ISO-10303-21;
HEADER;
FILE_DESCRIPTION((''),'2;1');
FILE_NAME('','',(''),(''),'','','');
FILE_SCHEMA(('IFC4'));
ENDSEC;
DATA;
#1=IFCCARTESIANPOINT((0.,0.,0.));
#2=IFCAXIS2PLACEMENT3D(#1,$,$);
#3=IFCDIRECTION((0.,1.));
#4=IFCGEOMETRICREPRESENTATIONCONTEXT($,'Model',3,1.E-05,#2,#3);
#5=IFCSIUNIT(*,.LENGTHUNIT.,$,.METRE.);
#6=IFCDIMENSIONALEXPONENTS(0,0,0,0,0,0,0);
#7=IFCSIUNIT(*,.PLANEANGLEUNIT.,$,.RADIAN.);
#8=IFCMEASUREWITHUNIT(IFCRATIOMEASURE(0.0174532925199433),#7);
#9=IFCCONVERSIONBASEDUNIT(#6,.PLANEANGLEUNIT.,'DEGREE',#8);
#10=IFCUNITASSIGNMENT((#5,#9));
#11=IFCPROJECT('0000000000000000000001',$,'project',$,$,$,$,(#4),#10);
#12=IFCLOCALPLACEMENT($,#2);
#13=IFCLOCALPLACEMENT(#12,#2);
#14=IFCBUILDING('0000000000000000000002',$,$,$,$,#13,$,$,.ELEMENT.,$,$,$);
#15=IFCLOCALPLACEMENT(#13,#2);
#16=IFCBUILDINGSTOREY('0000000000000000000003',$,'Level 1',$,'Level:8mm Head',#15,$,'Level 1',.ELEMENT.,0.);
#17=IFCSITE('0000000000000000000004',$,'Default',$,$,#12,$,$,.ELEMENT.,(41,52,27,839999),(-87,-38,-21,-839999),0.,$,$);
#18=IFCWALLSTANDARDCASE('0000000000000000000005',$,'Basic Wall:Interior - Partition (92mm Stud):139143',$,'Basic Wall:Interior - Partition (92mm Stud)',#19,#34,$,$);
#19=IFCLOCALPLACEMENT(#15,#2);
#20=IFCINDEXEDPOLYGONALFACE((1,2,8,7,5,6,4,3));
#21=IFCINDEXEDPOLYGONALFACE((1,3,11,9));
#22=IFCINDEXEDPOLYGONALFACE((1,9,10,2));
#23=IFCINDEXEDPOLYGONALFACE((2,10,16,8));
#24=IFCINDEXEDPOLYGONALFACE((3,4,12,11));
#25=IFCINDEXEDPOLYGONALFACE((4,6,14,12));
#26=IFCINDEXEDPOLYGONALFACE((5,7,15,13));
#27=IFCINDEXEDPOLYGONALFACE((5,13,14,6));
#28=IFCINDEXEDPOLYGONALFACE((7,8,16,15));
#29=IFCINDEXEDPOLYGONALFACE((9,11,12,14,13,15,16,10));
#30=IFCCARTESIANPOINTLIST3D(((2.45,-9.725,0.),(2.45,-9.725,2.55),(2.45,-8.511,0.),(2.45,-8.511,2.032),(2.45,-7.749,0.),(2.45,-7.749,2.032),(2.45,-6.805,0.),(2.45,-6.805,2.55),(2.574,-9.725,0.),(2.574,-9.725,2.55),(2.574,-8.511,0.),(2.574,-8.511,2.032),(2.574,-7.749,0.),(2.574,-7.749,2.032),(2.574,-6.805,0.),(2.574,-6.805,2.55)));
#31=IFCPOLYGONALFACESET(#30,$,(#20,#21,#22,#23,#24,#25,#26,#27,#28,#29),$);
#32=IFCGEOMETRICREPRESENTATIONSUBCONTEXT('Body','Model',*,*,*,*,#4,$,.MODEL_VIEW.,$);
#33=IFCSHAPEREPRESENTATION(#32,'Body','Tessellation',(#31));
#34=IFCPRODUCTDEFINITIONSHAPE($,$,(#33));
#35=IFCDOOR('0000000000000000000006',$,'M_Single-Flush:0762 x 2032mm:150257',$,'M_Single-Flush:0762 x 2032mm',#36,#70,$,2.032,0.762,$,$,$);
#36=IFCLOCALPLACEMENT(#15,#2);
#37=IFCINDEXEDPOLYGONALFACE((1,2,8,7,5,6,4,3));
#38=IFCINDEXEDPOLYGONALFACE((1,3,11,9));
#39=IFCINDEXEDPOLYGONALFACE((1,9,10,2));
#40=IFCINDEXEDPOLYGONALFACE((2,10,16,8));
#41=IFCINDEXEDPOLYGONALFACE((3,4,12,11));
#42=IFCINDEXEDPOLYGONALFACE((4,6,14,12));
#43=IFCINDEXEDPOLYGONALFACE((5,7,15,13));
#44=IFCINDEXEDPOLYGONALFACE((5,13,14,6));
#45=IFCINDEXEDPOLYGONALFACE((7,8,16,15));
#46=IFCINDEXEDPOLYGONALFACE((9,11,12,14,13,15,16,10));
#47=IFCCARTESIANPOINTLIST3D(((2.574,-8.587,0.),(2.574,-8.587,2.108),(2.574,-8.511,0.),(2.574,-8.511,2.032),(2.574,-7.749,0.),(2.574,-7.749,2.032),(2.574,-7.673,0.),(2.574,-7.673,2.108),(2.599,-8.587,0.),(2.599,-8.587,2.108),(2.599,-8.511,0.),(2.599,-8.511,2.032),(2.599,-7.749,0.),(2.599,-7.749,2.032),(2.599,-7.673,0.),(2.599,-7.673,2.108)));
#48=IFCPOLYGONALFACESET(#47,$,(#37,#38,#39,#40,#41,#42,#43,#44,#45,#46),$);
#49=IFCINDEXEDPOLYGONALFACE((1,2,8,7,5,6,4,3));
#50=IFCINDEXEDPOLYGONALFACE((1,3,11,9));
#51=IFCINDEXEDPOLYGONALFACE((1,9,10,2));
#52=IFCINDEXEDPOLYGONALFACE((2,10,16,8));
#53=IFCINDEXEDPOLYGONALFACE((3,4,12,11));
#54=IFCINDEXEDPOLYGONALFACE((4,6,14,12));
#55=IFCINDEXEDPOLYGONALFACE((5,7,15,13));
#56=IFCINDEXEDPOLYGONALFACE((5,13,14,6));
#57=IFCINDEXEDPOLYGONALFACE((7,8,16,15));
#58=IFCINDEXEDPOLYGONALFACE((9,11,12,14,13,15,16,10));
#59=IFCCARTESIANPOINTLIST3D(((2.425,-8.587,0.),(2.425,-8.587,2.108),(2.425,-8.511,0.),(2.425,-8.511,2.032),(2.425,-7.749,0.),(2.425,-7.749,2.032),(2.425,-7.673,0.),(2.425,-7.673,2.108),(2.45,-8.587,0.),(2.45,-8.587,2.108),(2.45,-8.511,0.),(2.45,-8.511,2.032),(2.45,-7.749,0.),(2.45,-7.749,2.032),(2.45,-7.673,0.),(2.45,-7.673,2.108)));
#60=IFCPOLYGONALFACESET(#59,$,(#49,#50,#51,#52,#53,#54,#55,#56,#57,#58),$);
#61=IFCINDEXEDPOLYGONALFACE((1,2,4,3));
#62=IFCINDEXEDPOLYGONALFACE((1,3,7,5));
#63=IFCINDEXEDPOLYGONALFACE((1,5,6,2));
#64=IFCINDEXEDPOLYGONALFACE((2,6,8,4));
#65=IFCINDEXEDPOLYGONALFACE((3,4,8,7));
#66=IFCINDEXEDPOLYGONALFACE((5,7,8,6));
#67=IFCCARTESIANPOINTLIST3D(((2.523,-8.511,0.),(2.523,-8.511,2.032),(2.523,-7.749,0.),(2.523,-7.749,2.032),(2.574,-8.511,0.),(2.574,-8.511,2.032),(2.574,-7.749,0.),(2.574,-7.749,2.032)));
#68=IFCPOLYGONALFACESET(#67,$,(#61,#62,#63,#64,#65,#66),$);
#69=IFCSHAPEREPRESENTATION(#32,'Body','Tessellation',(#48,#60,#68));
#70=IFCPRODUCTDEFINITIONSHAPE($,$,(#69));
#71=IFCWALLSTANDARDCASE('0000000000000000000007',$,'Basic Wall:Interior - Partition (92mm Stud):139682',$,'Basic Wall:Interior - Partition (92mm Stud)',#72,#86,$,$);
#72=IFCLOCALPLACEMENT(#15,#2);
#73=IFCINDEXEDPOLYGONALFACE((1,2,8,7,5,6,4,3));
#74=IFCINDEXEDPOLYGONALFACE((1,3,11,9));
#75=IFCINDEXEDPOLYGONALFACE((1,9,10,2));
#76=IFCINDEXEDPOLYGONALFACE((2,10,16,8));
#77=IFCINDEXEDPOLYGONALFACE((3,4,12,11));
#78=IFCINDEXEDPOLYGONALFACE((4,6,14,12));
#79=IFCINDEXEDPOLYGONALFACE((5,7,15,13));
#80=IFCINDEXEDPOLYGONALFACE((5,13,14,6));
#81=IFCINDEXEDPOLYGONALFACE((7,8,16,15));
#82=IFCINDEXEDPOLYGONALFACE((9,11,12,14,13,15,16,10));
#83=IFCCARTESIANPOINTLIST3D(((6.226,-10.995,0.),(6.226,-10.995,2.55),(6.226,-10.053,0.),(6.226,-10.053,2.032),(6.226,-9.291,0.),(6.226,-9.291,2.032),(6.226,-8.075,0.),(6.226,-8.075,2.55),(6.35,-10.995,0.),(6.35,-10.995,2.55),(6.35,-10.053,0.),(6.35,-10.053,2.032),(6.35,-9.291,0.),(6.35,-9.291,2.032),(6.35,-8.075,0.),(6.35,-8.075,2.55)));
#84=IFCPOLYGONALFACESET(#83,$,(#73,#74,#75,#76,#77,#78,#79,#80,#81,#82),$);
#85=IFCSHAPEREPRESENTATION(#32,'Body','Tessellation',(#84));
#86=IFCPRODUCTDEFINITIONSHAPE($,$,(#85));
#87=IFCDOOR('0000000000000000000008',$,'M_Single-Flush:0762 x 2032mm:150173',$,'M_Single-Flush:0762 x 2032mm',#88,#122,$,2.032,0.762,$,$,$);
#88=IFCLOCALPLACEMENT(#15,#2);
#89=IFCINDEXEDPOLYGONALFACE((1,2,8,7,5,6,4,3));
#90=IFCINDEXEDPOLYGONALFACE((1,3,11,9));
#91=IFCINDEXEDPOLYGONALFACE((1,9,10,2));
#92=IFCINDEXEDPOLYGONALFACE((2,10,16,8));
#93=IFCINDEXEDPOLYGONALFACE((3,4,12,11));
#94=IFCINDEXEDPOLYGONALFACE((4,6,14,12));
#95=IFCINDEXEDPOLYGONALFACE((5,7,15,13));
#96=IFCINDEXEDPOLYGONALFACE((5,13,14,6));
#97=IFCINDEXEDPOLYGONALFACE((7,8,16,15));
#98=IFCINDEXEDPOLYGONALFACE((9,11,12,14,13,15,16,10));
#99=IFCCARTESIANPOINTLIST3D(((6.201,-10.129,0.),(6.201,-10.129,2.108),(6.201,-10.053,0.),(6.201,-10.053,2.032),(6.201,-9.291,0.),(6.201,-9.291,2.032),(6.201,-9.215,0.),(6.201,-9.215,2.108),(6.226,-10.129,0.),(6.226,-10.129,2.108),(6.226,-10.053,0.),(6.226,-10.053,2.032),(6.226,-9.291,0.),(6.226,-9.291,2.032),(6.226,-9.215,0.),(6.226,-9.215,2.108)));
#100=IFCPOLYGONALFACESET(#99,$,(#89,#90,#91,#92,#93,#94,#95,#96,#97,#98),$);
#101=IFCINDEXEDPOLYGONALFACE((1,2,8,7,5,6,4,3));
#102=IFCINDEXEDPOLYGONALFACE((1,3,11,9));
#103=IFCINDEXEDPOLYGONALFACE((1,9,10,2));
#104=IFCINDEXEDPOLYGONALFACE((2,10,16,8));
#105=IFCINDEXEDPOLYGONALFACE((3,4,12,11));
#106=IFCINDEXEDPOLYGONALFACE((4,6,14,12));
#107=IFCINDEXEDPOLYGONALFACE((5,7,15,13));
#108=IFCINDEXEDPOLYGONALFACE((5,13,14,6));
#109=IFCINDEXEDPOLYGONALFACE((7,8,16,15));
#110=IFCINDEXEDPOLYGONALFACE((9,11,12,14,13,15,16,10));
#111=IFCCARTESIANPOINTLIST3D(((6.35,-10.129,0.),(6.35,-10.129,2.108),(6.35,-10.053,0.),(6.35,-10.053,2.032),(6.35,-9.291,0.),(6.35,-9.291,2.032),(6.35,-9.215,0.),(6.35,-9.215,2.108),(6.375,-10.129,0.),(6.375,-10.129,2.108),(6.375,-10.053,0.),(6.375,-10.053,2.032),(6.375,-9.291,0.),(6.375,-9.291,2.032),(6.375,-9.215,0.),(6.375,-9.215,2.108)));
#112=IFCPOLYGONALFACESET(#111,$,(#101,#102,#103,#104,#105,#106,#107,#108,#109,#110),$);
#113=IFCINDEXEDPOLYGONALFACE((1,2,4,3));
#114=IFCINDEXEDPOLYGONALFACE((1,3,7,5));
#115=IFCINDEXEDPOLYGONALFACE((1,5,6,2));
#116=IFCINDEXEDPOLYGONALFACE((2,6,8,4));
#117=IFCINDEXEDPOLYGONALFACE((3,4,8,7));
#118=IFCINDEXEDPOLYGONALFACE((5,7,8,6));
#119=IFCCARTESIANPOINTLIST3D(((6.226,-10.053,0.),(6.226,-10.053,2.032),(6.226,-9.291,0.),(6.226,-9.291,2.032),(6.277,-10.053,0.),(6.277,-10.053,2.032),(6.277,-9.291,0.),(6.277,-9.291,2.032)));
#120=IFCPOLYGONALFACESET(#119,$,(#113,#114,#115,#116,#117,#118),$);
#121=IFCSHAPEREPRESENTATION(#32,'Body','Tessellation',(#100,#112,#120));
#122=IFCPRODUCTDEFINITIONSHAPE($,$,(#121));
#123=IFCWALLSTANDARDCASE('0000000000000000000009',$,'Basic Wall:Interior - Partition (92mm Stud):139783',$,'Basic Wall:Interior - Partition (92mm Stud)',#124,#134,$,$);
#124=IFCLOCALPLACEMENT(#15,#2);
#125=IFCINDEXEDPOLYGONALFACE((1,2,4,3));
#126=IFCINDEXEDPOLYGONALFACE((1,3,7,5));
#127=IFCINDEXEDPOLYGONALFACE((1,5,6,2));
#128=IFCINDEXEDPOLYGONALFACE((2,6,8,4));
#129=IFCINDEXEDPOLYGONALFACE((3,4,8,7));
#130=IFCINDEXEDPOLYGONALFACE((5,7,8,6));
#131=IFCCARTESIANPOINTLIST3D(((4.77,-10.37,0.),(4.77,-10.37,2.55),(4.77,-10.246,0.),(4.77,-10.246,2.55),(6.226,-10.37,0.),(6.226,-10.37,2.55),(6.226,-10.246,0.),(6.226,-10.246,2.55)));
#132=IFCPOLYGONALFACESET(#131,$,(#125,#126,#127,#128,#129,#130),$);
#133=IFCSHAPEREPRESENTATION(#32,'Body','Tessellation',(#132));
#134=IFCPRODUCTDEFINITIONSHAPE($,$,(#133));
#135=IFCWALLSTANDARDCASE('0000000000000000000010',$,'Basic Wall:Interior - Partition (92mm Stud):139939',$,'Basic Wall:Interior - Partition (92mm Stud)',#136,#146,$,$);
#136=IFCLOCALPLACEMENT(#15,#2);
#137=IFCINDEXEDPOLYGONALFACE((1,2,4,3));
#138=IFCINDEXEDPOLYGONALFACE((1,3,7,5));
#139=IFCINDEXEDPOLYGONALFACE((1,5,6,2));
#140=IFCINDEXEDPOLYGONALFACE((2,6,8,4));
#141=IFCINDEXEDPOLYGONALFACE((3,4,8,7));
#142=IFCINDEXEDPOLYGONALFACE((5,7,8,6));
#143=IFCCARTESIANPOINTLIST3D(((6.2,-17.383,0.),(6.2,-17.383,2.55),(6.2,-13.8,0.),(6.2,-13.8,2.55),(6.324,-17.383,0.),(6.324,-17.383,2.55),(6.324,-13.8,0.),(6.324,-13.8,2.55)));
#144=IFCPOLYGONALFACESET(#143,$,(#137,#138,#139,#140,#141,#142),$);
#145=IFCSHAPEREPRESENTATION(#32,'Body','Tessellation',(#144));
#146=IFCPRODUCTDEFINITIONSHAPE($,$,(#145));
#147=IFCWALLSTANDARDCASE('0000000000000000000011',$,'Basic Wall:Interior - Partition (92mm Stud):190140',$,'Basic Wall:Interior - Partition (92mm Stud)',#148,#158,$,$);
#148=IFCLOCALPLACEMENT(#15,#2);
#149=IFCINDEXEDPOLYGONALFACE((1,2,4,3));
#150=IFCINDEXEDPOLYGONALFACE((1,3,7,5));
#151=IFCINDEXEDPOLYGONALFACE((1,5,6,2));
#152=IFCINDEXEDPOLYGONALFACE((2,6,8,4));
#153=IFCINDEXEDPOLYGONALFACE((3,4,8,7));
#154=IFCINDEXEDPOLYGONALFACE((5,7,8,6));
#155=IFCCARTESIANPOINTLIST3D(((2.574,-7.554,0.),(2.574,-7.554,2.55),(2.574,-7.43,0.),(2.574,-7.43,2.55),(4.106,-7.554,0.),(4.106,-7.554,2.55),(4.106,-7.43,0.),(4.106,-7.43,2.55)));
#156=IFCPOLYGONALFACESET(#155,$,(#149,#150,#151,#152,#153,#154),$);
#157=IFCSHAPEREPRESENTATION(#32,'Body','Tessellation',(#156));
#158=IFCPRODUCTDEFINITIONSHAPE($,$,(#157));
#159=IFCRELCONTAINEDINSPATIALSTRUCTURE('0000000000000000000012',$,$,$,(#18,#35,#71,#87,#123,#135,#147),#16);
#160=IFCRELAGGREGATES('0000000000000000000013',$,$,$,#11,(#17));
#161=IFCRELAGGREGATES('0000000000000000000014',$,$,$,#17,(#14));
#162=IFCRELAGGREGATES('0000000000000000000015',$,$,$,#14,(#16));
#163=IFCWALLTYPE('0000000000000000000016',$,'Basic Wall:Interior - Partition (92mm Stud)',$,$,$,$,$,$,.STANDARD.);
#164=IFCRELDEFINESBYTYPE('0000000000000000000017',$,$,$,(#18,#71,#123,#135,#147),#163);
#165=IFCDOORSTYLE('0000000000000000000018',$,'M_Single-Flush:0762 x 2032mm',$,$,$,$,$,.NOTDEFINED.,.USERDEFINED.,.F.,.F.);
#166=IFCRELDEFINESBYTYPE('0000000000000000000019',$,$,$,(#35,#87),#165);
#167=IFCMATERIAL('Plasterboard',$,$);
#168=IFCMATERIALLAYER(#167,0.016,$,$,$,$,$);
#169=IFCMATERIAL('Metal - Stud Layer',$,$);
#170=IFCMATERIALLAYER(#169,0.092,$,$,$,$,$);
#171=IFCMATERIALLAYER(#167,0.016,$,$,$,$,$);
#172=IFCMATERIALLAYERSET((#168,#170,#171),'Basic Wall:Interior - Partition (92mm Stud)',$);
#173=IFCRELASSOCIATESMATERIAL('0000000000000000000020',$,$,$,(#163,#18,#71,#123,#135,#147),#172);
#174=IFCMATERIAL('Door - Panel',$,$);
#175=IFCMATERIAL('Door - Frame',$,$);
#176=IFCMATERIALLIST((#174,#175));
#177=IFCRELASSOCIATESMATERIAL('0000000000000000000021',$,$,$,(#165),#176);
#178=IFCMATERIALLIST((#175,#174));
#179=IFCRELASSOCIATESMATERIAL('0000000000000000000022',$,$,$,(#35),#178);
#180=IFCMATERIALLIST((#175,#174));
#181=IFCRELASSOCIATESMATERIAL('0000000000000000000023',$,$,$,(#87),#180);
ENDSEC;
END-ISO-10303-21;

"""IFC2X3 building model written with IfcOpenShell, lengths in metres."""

from ifc_helpers import new_model, entity, si_unit, converted_unit, direction, frame, frame_2d, origin, place, context, subcontext, project, spatial, polyline, rectangle, outline, extrude, source, transform, mapped, material, material_list, layer, layer_set, layer_usage, type_object, type_shapes, element, fill, save


model = new_model("IFC2X3")

# Units and contexts
model_context = context("Model", 3, precision=1e-05, world=origin(), true_north=direction((0.0, 1.0)))
body_context = subcontext(model_context, "Body", "Model", "MODEL_VIEW")
ifc_project = project(units=[si_unit("LENGTHUNIT", "METRE"), converted_unit("PLANEANGLEUNIT", "DEGREE", entity("IfcRatioMeasure", 0.0174532925199433), si_unit("PLANEANGLEUNIT", "RADIAN"), dimensions=[0, 0, 0, 0, 0, 0, 0])], contexts=[model_context])

# Site, building, storey
site_placement = place(None, origin())
site = spatial("IfcSite", under=ifc_project, at=site_placement, Name="Default", CompositionType="ELEMENT", RefLatitude=(41, 52, 27, 839999), RefLongitude=(-87, -38, -21, -839999), RefElevation=0.0)
building_placement = place(site_placement, origin())
building = spatial("IfcBuilding", under=site, at=building_placement, CompositionType="ELEMENT")
storey_placement = place(building_placement, origin())
storey = spatial("IfcBuildingStorey", under=building, at=storey_placement, Name="Level 1", ObjectType="Level:8mm Head", LongName="Level 1", CompositionType="ELEMENT", Elevation=0.0)

# Shared definitions
ifc_material_1 = material(Name="Metal - Stud Layer")
ifc_material_2 = material(Name="Plasterboard")
ifc_material_3 = material(Name="Door - Frame")
ifc_material_4 = material(Name="Door - Panel")

# Walls, openings, doors
ifc_layer_1 = layer(ifc_material_2, 0.016)
ifc_layer_2 = layer(ifc_material_1, 0.092)
ifc_layer_3 = layer(ifc_material_2, 0.016)
ifc_layer_set_1 = layer_set([ifc_layer_1, ifc_layer_2, ifc_layer_3], Name="Basic Wall:Interior - Partition (92mm Stud)")
ifc_layer_usage_1 = layer_usage(ifc_layer_set_1, "AXIS2", "NEGATIVE", 0.062)
wall_type_1 = type_object("IfcWallType", Name="Basic Wall:Interior - Partition (92mm Stud)", PredefinedType="STANDARD", material=ifc_layer_set_1)
wall_1_placement = place(storey_placement, frame((2.512, -6.805, 0.0), z_axis=(0.0, 0.0, 1.0), x_axis=(0.0, -1.0, 0.0)))
wall_1 = element("IfcWallStandardCase", 1, at=wall_1_placement, inside=storey, type_object=wall_type_1, material=ifc_layer_usage_1, Name="Basic Wall:Interior - Partition (92mm Stud):139143", ObjectType="Basic Wall:Interior - Partition (92mm Stud)", context=body_context, shape_type="SweptSolid", body=[
    extrude(rectangle(XDim=2.92, YDim=0.124, at=frame_2d((1.46, 0.0), x_axis=(-1.0, 0.0))), origin(), (0.0, 0.0, 1.0), 2.55),
])
opening_1_placement = place(wall_1_placement, frame((0.944, -0.062, 0.0)))
opening_1 = element("IfcOpeningElement", 2, at=opening_1_placement, cuts=wall_1, ObjectType="Opening", context=body_context, shape_type="SweptSolid", body=[
    extrude(rectangle(XDim=0.762, YDim=2.032, at=frame_2d((1.016, 0.381), x_axis=(0.0, -1.0))), frame((0.0, 0.0, 0.0), z_axis=(0.0, 1.0, 0.0), x_axis=(0.0, 0.0, 1.0)), (0.0, 0.0, 1.0), 0.124),
])
ifc_material_list_1 = material_list([ifc_material_3, ifc_material_4])
ifc_material_list_2 = material_list([ifc_material_4, ifc_material_3])
door_style_1 = type_object("IfcDoorStyle", Name="M_Single-Flush:0762 x 2032mm", ConstructionType="USERDEFINED", OperationType="NOTDEFINED", ParameterTakesPrecedence=False, Sizeable=False, material=ifc_material_list_2)
shared_shape_1 = source(origin(), body_context, "Body", "SweptSolid", [
    extrude(outline(polyline([(-0.457, -1.073), (0.457, -1.073), (0.457, 1.035), (0.381, 1.035), (0.381, -0.997), (-0.381, -0.997), (-0.381, 1.035), (-0.457, 1.035), (-0.457, -1.073)])), frame((0.381, 0.149, 1.035), z_axis=(0.0, -1.0, 0.0), x_axis=(-1.0, 0.0, 0.0)), (0.0, 0.0, 1.0), 0.025),
    extrude(outline(polyline([(-1.073, -0.457), (1.035, -0.457), (1.035, -0.381), (-0.997, -0.381), (-0.997, 0.381), (1.035, 0.381), (1.035, 0.457), (-1.073, 0.457), (-1.073, -0.457)])), frame((0.381, 0.0, 1.035), z_axis=(0.0, -1.0, 0.0), x_axis=(0.0, 0.0, -1.0)), (0.0, 0.0, 1.0), 0.025),
    extrude(rectangle(XDim=0.762, YDim=0.051, at=frame_2d((0.0, 0.0), x_axis=(1.0, 0.0))), frame((0.381, 0.0985, 0.0)), (0.0, 0.0, 1.0), 2.032),
])
type_shapes(door_style_1, [shared_shape_1])
door_1_placement = place(opening_1_placement, origin())
door_1 = element("IfcDoor", 3, at=door_1_placement, inside=storey, type_object=door_style_1, material=ifc_material_list_1, Name="M_Single-Flush:0762 x 2032mm:150257", ObjectType="M_Single-Flush:0762 x 2032mm", OverallHeight=2.032, OverallWidth=0.762, context=body_context, shape_type="MappedRepresentation", body=[
    mapped(shared_shape_1, transform((0.0, 0.0, 0.0), scale=1.0)),
])
fill(opening_1, door_1)
ifc_layer_usage_2 = layer_usage(ifc_layer_set_1, "AXIS2", "NEGATIVE", 0.062)
wall_2_placement = place(storey_placement, frame((6.288, -10.995, 0.0), z_axis=(0.0, 0.0, 1.0), x_axis=(0.0, 1.0, 0.0)))
wall_2 = element("IfcWallStandardCase", 4, at=wall_2_placement, inside=storey, type_object=wall_type_1, material=ifc_layer_usage_2, Name="Basic Wall:Interior - Partition (92mm Stud):139682", ObjectType="Basic Wall:Interior - Partition (92mm Stud)", context=body_context, shape_type="SweptSolid", body=[
    extrude(rectangle(XDim=2.92, YDim=0.124, at=frame_2d((1.46, 0.0), x_axis=(-1.0, 0.0))), origin(), (0.0, 0.0, 1.0), 2.55),
])
opening_2_placement = place(wall_2_placement, frame((0.942, -0.062, 0.0)))
opening_2 = element("IfcOpeningElement", 5, at=opening_2_placement, cuts=wall_2, ObjectType="Opening", context=body_context, shape_type="SweptSolid", body=[
    extrude(rectangle(XDim=0.762, YDim=2.032, at=frame_2d((1.016, 0.381), x_axis=(0.0, -1.0))), frame((0.0, 0.0, 0.0), z_axis=(0.0, 1.0, 0.0), x_axis=(0.0, 0.0, 1.0)), (0.0, 0.0, 1.0), 0.124),
])
ifc_material_list_3 = material_list([ifc_material_3, ifc_material_4])
door_2_placement = place(opening_2_placement, origin())
door_2 = element("IfcDoor", 6, at=door_2_placement, inside=storey, type_object=door_style_1, material=ifc_material_list_3, Name="M_Single-Flush:0762 x 2032mm:150173", ObjectType="M_Single-Flush:0762 x 2032mm", OverallHeight=2.032, OverallWidth=0.762, context=body_context, shape_type="MappedRepresentation", body=[
    mapped(shared_shape_1, transform((0.0, 0.0, 0.0), scale=1.0)),
])
fill(opening_2, door_2)

# Walls
ifc_layer_usage_3 = layer_usage(ifc_layer_set_1, "AXIS2", "NEGATIVE", 0.062)
wall_3_placement = place(storey_placement, frame((4.77, -10.308, 0.0)))
element("IfcWallStandardCase", 7, at=wall_3_placement, inside=storey, type_object=wall_type_1, material=ifc_layer_usage_3, Name="Basic Wall:Interior - Partition (92mm Stud):139783", ObjectType="Basic Wall:Interior - Partition (92mm Stud)", context=body_context, shape_type="SweptSolid", body=[
    extrude(rectangle(XDim=1.456, YDim=0.124, at=frame_2d((0.728, 0.0), x_axis=(-1.0, 0.0))), origin(), (0.0, 0.0, 1.0), 2.55),
])
ifc_layer_usage_4 = layer_usage(ifc_layer_set_1, "AXIS2", "NEGATIVE", 0.062)
wall_4_placement = place(storey_placement, frame((6.262, -13.8, 0.0), z_axis=(0.0, 0.0, 1.0), x_axis=(0.0, -1.0, 0.0)))
element("IfcWallStandardCase", 8, at=wall_4_placement, inside=storey, type_object=wall_type_1, material=ifc_layer_usage_4, Name="Basic Wall:Interior - Partition (92mm Stud):139939", ObjectType="Basic Wall:Interior - Partition (92mm Stud)", context=body_context, shape_type="SweptSolid", body=[
    extrude(rectangle(XDim=3.583, YDim=0.124, at=frame_2d((1.7915, 0.0), x_axis=(-1.0, 0.0))), origin(), (0.0, 0.0, 1.0), 2.55),
])
ifc_layer_usage_5 = layer_usage(ifc_layer_set_1, "AXIS2", "NEGATIVE", 0.062)
wall_5_placement = place(storey_placement, frame((4.106, -7.492, 0.0), z_axis=(0.0, 0.0, 1.0), x_axis=(-1.0, 0.0, 0.0)))
element("IfcWallStandardCase", 9, at=wall_5_placement, inside=storey, type_object=wall_type_1, material=ifc_layer_usage_5, Name="Basic Wall:Interior - Partition (92mm Stud):190140", ObjectType="Basic Wall:Interior - Partition (92mm Stud)", context=body_context, shape_type="SweptSolid", body=[
    extrude(rectangle(XDim=1.532, YDim=0.124, at=frame_2d((0.766, 0.0), x_axis=(-1.0, 0.0))), origin(), (0.0, 0.0, 1.0), 2.55),
])

save(model, "model.ifc")
